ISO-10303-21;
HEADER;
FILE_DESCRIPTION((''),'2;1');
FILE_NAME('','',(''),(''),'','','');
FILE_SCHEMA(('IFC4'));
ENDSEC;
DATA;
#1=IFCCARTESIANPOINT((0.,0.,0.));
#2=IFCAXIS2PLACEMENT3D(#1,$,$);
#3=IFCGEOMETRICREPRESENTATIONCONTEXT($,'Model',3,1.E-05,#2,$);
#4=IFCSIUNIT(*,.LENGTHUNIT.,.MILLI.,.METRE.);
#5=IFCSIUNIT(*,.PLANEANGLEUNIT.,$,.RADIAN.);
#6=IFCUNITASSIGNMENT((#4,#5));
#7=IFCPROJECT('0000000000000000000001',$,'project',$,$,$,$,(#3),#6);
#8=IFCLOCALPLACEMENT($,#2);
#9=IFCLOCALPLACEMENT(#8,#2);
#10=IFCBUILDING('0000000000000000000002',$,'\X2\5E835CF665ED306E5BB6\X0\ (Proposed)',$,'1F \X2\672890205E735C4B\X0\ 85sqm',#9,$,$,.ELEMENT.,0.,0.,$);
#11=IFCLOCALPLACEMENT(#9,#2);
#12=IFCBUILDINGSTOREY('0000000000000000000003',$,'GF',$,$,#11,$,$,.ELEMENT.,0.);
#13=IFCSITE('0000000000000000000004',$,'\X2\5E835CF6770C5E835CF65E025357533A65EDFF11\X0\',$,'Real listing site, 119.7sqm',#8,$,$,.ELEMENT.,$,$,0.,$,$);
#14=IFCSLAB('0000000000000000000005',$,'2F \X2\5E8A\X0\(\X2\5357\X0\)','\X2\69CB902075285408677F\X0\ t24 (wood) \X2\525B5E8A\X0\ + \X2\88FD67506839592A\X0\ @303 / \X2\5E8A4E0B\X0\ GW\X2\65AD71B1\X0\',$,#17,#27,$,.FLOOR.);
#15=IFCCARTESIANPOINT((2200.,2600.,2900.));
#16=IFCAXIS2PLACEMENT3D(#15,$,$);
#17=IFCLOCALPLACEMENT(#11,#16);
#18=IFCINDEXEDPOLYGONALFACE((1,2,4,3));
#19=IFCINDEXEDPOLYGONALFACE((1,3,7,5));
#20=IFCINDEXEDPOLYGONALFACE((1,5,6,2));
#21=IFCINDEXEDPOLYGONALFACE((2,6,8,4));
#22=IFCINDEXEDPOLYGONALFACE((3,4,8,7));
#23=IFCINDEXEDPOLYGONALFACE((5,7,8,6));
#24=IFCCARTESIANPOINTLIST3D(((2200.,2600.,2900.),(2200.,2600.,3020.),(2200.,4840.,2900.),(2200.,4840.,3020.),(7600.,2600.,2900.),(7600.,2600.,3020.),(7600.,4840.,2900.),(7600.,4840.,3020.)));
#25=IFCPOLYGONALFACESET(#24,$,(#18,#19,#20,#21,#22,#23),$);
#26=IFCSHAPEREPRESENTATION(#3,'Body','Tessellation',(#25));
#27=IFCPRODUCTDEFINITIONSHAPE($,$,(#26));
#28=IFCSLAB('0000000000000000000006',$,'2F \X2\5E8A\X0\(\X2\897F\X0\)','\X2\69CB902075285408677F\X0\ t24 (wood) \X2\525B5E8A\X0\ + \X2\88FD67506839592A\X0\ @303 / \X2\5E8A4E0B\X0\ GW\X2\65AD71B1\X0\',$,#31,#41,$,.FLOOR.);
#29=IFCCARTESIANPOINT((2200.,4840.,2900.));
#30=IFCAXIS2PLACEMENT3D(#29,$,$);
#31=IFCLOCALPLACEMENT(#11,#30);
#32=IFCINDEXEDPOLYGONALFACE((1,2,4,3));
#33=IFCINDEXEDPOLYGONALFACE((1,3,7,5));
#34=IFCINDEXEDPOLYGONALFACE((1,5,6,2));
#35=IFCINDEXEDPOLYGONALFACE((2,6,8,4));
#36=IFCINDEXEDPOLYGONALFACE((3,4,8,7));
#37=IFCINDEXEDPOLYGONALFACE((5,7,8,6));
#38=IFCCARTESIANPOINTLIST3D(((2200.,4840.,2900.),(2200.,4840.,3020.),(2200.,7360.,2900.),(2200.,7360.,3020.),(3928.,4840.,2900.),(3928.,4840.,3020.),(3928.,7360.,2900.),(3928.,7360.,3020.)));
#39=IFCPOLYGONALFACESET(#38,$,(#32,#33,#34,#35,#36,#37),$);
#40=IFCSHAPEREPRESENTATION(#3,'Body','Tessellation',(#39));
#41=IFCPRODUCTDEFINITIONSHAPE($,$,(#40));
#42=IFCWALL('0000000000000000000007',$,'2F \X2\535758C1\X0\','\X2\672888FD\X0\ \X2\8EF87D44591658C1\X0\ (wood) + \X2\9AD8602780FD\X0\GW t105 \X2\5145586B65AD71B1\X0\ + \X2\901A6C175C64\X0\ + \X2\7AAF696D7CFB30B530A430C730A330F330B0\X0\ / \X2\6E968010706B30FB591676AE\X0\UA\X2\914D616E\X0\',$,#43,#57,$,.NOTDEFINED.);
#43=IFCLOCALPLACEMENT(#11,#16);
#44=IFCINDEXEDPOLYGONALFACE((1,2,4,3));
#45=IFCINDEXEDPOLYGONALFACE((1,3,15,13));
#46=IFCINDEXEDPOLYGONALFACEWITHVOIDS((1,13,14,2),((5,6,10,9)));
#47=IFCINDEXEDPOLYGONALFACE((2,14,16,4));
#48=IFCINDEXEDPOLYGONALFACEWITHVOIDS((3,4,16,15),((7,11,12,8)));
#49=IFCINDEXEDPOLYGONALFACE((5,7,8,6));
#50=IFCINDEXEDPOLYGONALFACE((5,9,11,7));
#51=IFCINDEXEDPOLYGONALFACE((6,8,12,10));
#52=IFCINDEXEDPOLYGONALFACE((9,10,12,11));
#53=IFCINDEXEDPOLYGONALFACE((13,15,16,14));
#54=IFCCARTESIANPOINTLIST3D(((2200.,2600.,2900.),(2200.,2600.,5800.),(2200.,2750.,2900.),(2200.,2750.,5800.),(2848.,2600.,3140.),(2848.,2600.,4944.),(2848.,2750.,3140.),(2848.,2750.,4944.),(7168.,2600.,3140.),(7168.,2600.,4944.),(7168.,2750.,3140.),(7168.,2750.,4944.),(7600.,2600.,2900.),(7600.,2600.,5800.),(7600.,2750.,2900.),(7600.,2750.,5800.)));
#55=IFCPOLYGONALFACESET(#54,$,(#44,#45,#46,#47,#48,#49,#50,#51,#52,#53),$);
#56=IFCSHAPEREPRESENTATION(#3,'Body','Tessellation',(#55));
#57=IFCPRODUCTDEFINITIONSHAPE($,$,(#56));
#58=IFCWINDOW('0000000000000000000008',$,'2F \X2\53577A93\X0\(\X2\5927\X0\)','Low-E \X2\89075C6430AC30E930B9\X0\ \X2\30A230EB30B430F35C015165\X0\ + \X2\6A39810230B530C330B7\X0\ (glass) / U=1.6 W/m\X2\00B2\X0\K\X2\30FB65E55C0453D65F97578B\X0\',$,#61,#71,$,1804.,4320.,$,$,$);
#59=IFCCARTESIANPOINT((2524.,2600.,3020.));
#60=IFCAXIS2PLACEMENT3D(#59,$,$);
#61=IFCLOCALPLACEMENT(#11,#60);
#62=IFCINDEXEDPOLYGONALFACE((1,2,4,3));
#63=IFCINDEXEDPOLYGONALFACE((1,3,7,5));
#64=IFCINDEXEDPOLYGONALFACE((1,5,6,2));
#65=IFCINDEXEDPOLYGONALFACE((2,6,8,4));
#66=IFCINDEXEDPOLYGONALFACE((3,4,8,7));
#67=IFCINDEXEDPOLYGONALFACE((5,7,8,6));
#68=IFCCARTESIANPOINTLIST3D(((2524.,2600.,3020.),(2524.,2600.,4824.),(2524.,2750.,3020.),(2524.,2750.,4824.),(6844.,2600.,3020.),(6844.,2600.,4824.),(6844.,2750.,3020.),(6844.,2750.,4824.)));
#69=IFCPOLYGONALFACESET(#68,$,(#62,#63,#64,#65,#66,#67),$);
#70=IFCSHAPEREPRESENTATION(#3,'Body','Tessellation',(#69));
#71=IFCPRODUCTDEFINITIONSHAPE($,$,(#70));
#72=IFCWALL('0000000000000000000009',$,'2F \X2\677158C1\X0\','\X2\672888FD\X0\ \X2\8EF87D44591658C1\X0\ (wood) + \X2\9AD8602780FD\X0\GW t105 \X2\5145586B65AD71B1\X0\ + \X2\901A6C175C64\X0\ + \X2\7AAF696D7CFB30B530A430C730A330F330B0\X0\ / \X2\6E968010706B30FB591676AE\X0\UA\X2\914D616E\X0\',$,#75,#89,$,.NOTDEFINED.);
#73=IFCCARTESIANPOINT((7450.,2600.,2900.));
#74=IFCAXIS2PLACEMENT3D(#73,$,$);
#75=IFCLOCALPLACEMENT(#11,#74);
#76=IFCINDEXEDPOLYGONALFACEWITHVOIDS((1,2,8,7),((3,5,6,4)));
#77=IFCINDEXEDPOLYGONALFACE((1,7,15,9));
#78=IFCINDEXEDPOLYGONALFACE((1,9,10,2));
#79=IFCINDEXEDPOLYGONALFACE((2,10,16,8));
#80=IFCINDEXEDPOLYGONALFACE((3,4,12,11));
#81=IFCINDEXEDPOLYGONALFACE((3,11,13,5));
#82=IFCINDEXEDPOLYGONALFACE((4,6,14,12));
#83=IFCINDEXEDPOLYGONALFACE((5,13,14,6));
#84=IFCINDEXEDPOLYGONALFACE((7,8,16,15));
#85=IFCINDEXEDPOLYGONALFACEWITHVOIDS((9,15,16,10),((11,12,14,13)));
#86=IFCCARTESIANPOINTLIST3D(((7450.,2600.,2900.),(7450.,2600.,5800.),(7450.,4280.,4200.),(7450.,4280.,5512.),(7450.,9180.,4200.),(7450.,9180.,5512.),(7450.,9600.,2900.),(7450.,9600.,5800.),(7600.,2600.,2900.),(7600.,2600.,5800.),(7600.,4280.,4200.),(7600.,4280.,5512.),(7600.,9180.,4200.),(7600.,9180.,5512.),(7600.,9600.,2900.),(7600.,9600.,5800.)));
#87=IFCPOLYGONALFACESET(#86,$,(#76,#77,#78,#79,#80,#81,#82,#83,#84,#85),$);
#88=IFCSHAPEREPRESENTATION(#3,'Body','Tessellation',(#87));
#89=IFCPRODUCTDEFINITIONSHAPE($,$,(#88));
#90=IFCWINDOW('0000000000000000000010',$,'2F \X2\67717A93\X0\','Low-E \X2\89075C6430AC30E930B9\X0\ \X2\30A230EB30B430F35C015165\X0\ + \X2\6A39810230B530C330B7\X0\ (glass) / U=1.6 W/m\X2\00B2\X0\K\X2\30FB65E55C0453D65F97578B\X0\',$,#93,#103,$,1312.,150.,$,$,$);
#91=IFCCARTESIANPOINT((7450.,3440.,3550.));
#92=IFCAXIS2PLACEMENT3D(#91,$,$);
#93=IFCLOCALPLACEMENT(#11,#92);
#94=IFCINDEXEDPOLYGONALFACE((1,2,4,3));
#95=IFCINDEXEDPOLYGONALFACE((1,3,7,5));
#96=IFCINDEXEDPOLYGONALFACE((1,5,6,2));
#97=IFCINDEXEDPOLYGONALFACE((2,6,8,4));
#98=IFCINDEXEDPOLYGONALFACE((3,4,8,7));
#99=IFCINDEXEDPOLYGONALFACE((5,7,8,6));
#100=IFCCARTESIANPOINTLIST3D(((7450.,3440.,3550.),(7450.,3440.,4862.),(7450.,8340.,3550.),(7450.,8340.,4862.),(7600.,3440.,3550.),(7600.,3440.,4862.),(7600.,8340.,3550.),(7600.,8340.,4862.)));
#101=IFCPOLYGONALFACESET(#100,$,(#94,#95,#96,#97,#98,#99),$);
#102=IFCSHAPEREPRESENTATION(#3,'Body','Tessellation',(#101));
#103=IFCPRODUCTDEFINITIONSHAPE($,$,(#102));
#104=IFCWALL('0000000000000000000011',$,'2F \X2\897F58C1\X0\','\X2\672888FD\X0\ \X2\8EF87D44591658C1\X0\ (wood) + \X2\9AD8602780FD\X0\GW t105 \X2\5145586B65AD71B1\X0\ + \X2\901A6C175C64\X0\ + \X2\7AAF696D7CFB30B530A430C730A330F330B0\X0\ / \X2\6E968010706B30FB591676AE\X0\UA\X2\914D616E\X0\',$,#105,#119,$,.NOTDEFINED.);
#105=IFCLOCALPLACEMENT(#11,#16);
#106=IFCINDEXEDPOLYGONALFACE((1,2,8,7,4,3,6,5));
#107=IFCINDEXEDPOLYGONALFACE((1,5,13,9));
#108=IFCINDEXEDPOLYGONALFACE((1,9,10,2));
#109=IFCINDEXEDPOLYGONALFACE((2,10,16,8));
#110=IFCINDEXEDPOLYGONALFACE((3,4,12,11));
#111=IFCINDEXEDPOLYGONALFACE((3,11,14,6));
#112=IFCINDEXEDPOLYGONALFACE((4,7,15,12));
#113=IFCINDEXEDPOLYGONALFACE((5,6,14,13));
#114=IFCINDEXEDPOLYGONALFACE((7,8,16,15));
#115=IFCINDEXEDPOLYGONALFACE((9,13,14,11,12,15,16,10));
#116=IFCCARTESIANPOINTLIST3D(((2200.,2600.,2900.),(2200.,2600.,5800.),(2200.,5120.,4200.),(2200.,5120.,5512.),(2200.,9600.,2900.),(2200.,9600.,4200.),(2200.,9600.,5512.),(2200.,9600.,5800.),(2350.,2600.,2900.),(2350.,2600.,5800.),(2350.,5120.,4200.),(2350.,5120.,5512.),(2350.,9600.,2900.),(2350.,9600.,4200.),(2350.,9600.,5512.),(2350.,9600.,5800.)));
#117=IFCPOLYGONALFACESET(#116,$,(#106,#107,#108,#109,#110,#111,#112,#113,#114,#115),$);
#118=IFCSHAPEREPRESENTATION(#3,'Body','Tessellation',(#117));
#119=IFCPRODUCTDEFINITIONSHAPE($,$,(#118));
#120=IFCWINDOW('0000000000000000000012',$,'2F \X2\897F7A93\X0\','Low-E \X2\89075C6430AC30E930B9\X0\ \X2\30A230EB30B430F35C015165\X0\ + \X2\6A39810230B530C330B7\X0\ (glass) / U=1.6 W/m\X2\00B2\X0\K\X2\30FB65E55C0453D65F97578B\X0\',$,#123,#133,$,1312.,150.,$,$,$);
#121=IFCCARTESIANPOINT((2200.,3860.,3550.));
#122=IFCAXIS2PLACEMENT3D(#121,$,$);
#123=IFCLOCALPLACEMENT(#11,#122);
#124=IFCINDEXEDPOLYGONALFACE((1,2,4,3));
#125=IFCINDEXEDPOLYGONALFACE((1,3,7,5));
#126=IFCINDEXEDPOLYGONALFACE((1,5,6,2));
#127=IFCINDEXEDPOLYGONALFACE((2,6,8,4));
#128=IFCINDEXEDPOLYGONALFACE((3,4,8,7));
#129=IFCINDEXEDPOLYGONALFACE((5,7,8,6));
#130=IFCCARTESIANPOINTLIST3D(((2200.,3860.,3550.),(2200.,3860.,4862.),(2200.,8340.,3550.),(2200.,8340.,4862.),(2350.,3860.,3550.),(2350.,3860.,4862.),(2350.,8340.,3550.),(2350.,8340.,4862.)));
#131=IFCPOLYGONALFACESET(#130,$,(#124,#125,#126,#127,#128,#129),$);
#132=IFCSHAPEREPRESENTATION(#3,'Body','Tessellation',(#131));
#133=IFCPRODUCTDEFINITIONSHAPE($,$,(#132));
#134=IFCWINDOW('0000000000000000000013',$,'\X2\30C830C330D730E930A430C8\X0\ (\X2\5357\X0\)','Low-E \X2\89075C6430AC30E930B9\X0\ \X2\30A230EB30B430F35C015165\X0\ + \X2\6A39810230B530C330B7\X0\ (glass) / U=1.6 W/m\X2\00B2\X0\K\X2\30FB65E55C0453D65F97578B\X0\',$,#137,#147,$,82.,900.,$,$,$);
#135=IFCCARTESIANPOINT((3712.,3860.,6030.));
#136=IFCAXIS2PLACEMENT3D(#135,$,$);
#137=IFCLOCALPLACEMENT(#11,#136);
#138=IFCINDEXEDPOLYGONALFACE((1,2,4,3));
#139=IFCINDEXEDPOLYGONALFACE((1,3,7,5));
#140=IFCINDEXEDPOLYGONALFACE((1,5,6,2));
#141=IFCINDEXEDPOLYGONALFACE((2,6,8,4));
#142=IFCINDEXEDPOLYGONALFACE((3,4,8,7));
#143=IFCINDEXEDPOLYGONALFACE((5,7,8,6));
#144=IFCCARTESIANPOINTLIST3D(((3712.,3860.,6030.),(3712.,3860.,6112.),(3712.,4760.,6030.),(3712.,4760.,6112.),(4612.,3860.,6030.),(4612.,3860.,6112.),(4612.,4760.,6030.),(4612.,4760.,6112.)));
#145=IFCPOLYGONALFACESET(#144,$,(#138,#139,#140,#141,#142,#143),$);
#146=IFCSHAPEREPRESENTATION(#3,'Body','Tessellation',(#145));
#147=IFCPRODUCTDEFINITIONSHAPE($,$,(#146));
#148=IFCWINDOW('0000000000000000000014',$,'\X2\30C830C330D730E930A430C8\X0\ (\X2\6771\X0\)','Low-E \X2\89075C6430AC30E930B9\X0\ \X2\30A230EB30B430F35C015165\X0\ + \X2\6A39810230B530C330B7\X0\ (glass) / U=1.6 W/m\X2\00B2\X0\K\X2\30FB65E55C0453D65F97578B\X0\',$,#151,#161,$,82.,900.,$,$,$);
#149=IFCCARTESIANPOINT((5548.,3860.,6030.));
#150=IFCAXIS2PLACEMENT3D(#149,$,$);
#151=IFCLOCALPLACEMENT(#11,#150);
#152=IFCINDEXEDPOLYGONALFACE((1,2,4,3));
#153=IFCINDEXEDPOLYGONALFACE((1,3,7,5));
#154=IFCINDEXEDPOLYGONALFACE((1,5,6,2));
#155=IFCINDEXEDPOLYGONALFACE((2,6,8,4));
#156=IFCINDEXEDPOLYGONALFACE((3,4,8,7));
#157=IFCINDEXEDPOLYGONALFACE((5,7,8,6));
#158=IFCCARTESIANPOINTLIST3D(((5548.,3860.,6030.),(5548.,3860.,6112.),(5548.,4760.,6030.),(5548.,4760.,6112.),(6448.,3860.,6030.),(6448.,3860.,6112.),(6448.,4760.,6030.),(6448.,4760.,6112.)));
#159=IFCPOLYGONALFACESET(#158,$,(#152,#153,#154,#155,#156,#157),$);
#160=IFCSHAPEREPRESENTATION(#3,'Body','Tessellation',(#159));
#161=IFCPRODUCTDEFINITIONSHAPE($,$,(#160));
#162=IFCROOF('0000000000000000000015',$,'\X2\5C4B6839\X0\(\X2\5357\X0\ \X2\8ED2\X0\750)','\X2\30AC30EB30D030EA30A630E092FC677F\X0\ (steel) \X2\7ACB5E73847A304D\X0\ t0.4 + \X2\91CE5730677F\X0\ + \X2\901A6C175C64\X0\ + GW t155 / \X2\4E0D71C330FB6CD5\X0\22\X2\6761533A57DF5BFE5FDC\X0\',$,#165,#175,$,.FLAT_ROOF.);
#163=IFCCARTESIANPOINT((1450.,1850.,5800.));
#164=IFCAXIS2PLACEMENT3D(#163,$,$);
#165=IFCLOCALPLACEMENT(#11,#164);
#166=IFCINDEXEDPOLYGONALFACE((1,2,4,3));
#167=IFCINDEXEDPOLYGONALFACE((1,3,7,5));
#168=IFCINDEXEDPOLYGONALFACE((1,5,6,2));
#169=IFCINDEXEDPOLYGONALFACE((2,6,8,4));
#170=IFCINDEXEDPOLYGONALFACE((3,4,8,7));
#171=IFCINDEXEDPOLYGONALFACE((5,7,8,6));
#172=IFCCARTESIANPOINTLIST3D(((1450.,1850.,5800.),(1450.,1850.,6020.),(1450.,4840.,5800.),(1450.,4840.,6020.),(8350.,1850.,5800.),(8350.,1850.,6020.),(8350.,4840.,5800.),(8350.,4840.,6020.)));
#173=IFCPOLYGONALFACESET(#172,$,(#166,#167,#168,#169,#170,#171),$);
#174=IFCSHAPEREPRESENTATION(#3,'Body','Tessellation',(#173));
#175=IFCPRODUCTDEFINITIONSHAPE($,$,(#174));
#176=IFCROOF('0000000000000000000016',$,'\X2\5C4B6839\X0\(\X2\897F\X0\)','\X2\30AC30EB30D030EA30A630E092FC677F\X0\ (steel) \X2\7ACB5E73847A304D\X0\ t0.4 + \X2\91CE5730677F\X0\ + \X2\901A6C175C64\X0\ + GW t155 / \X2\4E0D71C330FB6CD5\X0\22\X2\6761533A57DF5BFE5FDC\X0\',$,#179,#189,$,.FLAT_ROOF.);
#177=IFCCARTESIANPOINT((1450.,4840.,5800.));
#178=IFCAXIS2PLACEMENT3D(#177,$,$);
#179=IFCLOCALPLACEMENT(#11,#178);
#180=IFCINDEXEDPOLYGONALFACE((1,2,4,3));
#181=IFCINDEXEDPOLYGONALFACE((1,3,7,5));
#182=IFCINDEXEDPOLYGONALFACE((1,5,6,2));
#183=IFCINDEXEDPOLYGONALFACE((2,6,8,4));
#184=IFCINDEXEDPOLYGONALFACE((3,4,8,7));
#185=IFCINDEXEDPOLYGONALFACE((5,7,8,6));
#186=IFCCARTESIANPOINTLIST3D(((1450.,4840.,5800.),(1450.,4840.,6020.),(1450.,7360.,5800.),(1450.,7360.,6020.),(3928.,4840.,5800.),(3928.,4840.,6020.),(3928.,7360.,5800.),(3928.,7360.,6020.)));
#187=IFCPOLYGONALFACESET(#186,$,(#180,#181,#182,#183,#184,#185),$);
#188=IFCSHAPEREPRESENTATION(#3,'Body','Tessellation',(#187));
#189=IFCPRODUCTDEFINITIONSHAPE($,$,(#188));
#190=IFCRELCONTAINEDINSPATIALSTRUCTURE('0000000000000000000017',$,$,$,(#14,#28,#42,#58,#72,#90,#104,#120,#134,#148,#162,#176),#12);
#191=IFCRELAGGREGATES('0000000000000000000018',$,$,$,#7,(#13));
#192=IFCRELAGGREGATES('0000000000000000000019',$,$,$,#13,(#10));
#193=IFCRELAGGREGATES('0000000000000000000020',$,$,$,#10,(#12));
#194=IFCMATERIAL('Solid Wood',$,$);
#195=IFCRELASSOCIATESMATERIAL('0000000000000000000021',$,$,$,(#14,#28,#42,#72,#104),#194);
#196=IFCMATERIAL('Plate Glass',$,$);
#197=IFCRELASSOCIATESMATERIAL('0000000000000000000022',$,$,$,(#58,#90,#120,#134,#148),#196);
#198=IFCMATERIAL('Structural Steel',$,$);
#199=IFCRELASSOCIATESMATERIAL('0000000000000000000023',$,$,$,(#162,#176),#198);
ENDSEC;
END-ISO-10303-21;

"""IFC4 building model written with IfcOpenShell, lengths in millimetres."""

from ifc_helpers import new_model, si_unit, frame, frame_2d, origin, place, context, project, spatial, rectangle, extrude, material, element, fill, save


model = new_model("IFC4")

# Units and contexts
model_context = context("Model", 3, precision=1e-05, world=origin())
ifc_project = project(units=[si_unit("LENGTHUNIT", "METRE", prefix="MILLI"), si_unit("PLANEANGLEUNIT", "RADIAN")], contexts=[model_context])

# Site, building, storey
site_placement = place(None, origin())
site = spatial("IfcSite", under=ifc_project, at=site_placement, Name="広島県広島市南区旭１", ObjectType="Real listing site, 119.7sqm", CompositionType="ELEMENT", RefElevation=0.0)
building_placement = place(site_placement, origin())
building = spatial("IfcBuilding", under=site, at=building_placement, Name="広島旭の家 (Proposed)", ObjectType="1F 木造平屋 85sqm", CompositionType="ELEMENT", ElevationOfRefHeight=0.0, ElevationOfTerrain=0.0)
storey_placement = place(building_placement, origin())
storey = spatial("IfcBuildingStorey", under=building, at=storey_placement, Name="GF", CompositionType="ELEMENT", Elevation=0.0)

# Slabs
ifc_material_1 = material(Name="Solid Wood")
slab_1_placement = place(storey_placement, frame((2200.0, 2600.0, 2900.0)))
element("IfcSlab", 1, at=slab_1_placement, inside=storey, material=ifc_material_1, Name="2F 床(南)", Description="構造用合板 t24 (wood) 剛床 + 製材根太 @303 / 床下 GW断熱", PredefinedType="FLOOR", context=model_context, shape_type="SweptSolid", body=[
    extrude(rectangle(XDim=5400.0, YDim=2240.0, at=frame_2d((2700.0, 1120.0))), frame((2200.0, 2600.0, 2900.0)), (0.0, 0.0, 1.0), 120.0),
])
slab_2_placement = place(storey_placement, frame((2200.0, 4840.0, 2900.0)))
element("IfcSlab", 2, at=slab_2_placement, inside=storey, material=ifc_material_1, Name="2F 床(西)", Description="構造用合板 t24 (wood) 剛床 + 製材根太 @303 / 床下 GW断熱", PredefinedType="FLOOR", context=model_context, shape_type="SweptSolid", body=[
    extrude(rectangle(XDim=1728.0, YDim=2520.0, at=frame_2d((864.0, 1260.0))), frame((2200.0, 4840.0, 2900.0)), (0.0, 0.0, 1.0), 120.0),
])

# Walls, openings, windows
wall_1_placement = place(storey_placement, frame((2200.0, 2600.0, 2900.0)))
wall_1 = element("IfcWall", 3, at=wall_1_placement, inside=storey, material=ifc_material_1, Name="2F 南壁", Description="木製 軸組外壁 (wood) + 高性能GW t105 充填断熱 + 通気層 + 窯業系サイディング / 準耐火・外皮UA配慮", PredefinedType="NOTDEFINED", context=model_context, shape_type="SweptSolid", body=[
    extrude(rectangle(XDim=5400.0, YDim=150.0, at=frame_2d((2700.0, 75.0))), frame((2200.0, 2600.0, 2900.0)), (0.0, 0.0, 1.0), 2900.0),
])
opening_1_placement = place(storey_placement, frame((2524.0, 2600.0, 3020.0)))
opening_1 = element("IfcOpeningElement", 4, at=opening_1_placement, cuts=wall_1, PredefinedType="NOTDEFINED", context=model_context, shape_type="SweptSolid", body=[
    extrude(rectangle(XDim=4320.0, YDim=150.0, at=frame_2d((2160.0, 75.0))), frame((2524.0, 2600.0, 3020.0)), (0.0, 0.0, 1.0), 1804.0),
])
ifc_material_2 = material(Name="Plate Glass")
window_1_placement = place(storey_placement, frame((2524.0, 2600.0, 3020.0)))
window_1 = element("IfcWindow", 5, at=window_1_placement, inside=storey, material=ifc_material_2, Name="2F 南窓(大)", Description="Low-E 複層ガラス アルゴン封入 + 樹脂サッシ (glass) / U=1.6 W/m²K・日射取得型", OverallHeight=1804.0, OverallWidth=4320.0, context=model_context, shape_type="SweptSolid", body=[
    extrude(rectangle(XDim=4320.0, YDim=150.0, at=frame_2d((2160.0, 75.0))), frame((2524.0, 2600.0, 3020.0)), (0.0, 0.0, 1.0), 1804.0),
])
fill(opening_1, window_1)
wall_2_placement = place(storey_placement, frame((7450.0, 2600.0, 2900.0)))
wall_2 = element("IfcWall", 6, at=wall_2_placement, inside=storey, material=ifc_material_1, Name="2F 東壁", Description="木製 軸組外壁 (wood) + 高性能GW t105 充填断熱 + 通気層 + 窯業系サイディング / 準耐火・外皮UA配慮", PredefinedType="NOTDEFINED", context=model_context, shape_type="SweptSolid", body=[
    extrude(rectangle(XDim=150.0, YDim=7000.0, at=frame_2d((75.0, 3500.0))), frame((7450.0, 2600.0, 2900.0)), (0.0, 0.0, 1.0), 2900.0),
])
opening_2_placement = place(storey_placement, frame((7450.0, 3440.0, 3550.0)))
opening_2 = element("IfcOpeningElement", 7, at=opening_2_placement, cuts=wall_2, PredefinedType="NOTDEFINED", context=model_context, shape_type="SweptSolid", body=[
    extrude(rectangle(XDim=150.0, YDim=4900.0, at=frame_2d((75.0, 2450.0))), frame((7450.0, 3440.0, 3550.0)), (0.0, 0.0, 1.0), 1312.0),
])
window_2_placement = place(storey_placement, frame((7450.0, 3440.0, 3550.0)))
window_2 = element("IfcWindow", 8, at=window_2_placement, inside=storey, material=ifc_material_2, Name="2F 東窓", Description="Low-E 複層ガラス アルゴン封入 + 樹脂サッシ (glass) / U=1.6 W/m²K・日射取得型", OverallHeight=1312.0, OverallWidth=150.0, context=model_context, shape_type="SweptSolid", body=[
    extrude(rectangle(XDim=150.0, YDim=4900.0, at=frame_2d((75.0, 2450.0))), frame((7450.0, 3440.0, 3550.0)), (0.0, 0.0, 1.0), 1312.0),
])
fill(opening_2, window_2)
wall_3_placement = place(storey_placement, frame((2200.0, 2600.0, 2900.0)))
wall_3 = element("IfcWall", 9, at=wall_3_placement, inside=storey, material=ifc_material_1, Name="2F 西壁", Description="木製 軸組外壁 (wood) + 高性能GW t105 充填断熱 + 通気層 + 窯業系サイディング / 準耐火・外皮UA配慮", PredefinedType="NOTDEFINED", context=model_context, shape_type="SweptSolid", body=[
    extrude(rectangle(XDim=150.0, YDim=7000.0, at=frame_2d((75.0, 3500.0))), frame((2200.0, 2600.0, 2900.0)), (0.0, 0.0, 1.0), 2900.0),
])
opening_3_placement = place(storey_placement, frame((2200.0, 3860.0, 3550.0)))
opening_3 = element("IfcOpeningElement", 10, at=opening_3_placement, cuts=wall_3, PredefinedType="NOTDEFINED", context=model_context, shape_type="SweptSolid", body=[
    extrude(rectangle(XDim=150.0, YDim=4480.0, at=frame_2d((75.0, 2240.0))), frame((2200.0, 3860.0, 3550.0)), (0.0, 0.0, 1.0), 1312.0),
])
window_3_placement = place(storey_placement, frame((2200.0, 3860.0, 3550.0)))
window_3 = element("IfcWindow", 11, at=window_3_placement, inside=storey, material=ifc_material_2, Name="2F 西窓", Description="Low-E 複層ガラス アルゴン封入 + 樹脂サッシ (glass) / U=1.6 W/m²K・日射取得型", OverallHeight=1312.0, OverallWidth=150.0, context=model_context, shape_type="SweptSolid", body=[
    extrude(rectangle(XDim=150.0, YDim=4480.0, at=frame_2d((75.0, 2240.0))), frame((2200.0, 3860.0, 3550.0)), (0.0, 0.0, 1.0), 1312.0),
])
fill(opening_3, window_3)

# Windows
window_4_placement = place(storey_placement, frame((3712.0, 3860.0, 6030.0)))
element("IfcWindow", 12, at=window_4_placement, inside=storey, material=ifc_material_2, Name="トップライト (南)", Description="Low-E 複層ガラス アルゴン封入 + 樹脂サッシ (glass) / U=1.6 W/m²K・日射取得型", OverallHeight=82.0, OverallWidth=900.0, context=model_context, shape_type="SweptSolid", body=[
    extrude(rectangle(XDim=900.0, YDim=900.0, at=frame_2d((450.0, 450.0))), frame((3712.0, 3860.0, 6030.0)), (0.0, 0.0, 1.0), 82.0),
])
window_5_placement = place(storey_placement, frame((5548.0, 3860.0, 6030.0)))
element("IfcWindow", 13, at=window_5_placement, inside=storey, material=ifc_material_2, Name="トップライト (東)", Description="Low-E 複層ガラス アルゴン封入 + 樹脂サッシ (glass) / U=1.6 W/m²K・日射取得型", OverallHeight=82.0, OverallWidth=900.0, context=model_context, shape_type="SweptSolid", body=[
    extrude(rectangle(XDim=900.0, YDim=900.0, at=frame_2d((450.0, 450.0))), frame((5548.0, 3860.0, 6030.0)), (0.0, 0.0, 1.0), 82.0),
])

# Roofs
ifc_material_3 = material(Name="Structural Steel")
roof_1_placement = place(storey_placement, frame((1450.0, 1850.0, 5800.0)))
element("IfcRoof", 14, at=roof_1_placement, inside=storey, material=ifc_material_3, Name="屋根(南 軒750)", Description="ガルバリウム鋼板 (steel) 立平葺き t0.4 + 野地板 + 通気層 + GW t155 / 不燃・法22条区域対応", PredefinedType="FLAT_ROOF", context=model_context, shape_type="SweptSolid", body=[
    extrude(rectangle(XDim=6900.0, YDim=2990.0, at=frame_2d((3450.0, 1495.0))), frame((1450.0, 1850.0, 5800.0)), (0.0, 0.0, 1.0), 220.0),
])
roof_2_placement = place(storey_placement, frame((1450.0, 4840.0, 5800.0)))
element("IfcRoof", 15, at=roof_2_placement, inside=storey, material=ifc_material_3, Name="屋根(西)", Description="ガルバリウム鋼板 (steel) 立平葺き t0.4 + 野地板 + 通気層 + GW t155 / 不燃・法22条区域対応", PredefinedType="FLAT_ROOF", context=model_context, shape_type="SweptSolid", body=[
    extrude(rectangle(XDim=2478.0, YDim=2520.0, at=frame_2d((1239.0, 1260.0))), frame((1450.0, 4840.0, 5800.0)), (0.0, 0.0, 1.0), 220.0),
])

save(model, "model.ifc")
